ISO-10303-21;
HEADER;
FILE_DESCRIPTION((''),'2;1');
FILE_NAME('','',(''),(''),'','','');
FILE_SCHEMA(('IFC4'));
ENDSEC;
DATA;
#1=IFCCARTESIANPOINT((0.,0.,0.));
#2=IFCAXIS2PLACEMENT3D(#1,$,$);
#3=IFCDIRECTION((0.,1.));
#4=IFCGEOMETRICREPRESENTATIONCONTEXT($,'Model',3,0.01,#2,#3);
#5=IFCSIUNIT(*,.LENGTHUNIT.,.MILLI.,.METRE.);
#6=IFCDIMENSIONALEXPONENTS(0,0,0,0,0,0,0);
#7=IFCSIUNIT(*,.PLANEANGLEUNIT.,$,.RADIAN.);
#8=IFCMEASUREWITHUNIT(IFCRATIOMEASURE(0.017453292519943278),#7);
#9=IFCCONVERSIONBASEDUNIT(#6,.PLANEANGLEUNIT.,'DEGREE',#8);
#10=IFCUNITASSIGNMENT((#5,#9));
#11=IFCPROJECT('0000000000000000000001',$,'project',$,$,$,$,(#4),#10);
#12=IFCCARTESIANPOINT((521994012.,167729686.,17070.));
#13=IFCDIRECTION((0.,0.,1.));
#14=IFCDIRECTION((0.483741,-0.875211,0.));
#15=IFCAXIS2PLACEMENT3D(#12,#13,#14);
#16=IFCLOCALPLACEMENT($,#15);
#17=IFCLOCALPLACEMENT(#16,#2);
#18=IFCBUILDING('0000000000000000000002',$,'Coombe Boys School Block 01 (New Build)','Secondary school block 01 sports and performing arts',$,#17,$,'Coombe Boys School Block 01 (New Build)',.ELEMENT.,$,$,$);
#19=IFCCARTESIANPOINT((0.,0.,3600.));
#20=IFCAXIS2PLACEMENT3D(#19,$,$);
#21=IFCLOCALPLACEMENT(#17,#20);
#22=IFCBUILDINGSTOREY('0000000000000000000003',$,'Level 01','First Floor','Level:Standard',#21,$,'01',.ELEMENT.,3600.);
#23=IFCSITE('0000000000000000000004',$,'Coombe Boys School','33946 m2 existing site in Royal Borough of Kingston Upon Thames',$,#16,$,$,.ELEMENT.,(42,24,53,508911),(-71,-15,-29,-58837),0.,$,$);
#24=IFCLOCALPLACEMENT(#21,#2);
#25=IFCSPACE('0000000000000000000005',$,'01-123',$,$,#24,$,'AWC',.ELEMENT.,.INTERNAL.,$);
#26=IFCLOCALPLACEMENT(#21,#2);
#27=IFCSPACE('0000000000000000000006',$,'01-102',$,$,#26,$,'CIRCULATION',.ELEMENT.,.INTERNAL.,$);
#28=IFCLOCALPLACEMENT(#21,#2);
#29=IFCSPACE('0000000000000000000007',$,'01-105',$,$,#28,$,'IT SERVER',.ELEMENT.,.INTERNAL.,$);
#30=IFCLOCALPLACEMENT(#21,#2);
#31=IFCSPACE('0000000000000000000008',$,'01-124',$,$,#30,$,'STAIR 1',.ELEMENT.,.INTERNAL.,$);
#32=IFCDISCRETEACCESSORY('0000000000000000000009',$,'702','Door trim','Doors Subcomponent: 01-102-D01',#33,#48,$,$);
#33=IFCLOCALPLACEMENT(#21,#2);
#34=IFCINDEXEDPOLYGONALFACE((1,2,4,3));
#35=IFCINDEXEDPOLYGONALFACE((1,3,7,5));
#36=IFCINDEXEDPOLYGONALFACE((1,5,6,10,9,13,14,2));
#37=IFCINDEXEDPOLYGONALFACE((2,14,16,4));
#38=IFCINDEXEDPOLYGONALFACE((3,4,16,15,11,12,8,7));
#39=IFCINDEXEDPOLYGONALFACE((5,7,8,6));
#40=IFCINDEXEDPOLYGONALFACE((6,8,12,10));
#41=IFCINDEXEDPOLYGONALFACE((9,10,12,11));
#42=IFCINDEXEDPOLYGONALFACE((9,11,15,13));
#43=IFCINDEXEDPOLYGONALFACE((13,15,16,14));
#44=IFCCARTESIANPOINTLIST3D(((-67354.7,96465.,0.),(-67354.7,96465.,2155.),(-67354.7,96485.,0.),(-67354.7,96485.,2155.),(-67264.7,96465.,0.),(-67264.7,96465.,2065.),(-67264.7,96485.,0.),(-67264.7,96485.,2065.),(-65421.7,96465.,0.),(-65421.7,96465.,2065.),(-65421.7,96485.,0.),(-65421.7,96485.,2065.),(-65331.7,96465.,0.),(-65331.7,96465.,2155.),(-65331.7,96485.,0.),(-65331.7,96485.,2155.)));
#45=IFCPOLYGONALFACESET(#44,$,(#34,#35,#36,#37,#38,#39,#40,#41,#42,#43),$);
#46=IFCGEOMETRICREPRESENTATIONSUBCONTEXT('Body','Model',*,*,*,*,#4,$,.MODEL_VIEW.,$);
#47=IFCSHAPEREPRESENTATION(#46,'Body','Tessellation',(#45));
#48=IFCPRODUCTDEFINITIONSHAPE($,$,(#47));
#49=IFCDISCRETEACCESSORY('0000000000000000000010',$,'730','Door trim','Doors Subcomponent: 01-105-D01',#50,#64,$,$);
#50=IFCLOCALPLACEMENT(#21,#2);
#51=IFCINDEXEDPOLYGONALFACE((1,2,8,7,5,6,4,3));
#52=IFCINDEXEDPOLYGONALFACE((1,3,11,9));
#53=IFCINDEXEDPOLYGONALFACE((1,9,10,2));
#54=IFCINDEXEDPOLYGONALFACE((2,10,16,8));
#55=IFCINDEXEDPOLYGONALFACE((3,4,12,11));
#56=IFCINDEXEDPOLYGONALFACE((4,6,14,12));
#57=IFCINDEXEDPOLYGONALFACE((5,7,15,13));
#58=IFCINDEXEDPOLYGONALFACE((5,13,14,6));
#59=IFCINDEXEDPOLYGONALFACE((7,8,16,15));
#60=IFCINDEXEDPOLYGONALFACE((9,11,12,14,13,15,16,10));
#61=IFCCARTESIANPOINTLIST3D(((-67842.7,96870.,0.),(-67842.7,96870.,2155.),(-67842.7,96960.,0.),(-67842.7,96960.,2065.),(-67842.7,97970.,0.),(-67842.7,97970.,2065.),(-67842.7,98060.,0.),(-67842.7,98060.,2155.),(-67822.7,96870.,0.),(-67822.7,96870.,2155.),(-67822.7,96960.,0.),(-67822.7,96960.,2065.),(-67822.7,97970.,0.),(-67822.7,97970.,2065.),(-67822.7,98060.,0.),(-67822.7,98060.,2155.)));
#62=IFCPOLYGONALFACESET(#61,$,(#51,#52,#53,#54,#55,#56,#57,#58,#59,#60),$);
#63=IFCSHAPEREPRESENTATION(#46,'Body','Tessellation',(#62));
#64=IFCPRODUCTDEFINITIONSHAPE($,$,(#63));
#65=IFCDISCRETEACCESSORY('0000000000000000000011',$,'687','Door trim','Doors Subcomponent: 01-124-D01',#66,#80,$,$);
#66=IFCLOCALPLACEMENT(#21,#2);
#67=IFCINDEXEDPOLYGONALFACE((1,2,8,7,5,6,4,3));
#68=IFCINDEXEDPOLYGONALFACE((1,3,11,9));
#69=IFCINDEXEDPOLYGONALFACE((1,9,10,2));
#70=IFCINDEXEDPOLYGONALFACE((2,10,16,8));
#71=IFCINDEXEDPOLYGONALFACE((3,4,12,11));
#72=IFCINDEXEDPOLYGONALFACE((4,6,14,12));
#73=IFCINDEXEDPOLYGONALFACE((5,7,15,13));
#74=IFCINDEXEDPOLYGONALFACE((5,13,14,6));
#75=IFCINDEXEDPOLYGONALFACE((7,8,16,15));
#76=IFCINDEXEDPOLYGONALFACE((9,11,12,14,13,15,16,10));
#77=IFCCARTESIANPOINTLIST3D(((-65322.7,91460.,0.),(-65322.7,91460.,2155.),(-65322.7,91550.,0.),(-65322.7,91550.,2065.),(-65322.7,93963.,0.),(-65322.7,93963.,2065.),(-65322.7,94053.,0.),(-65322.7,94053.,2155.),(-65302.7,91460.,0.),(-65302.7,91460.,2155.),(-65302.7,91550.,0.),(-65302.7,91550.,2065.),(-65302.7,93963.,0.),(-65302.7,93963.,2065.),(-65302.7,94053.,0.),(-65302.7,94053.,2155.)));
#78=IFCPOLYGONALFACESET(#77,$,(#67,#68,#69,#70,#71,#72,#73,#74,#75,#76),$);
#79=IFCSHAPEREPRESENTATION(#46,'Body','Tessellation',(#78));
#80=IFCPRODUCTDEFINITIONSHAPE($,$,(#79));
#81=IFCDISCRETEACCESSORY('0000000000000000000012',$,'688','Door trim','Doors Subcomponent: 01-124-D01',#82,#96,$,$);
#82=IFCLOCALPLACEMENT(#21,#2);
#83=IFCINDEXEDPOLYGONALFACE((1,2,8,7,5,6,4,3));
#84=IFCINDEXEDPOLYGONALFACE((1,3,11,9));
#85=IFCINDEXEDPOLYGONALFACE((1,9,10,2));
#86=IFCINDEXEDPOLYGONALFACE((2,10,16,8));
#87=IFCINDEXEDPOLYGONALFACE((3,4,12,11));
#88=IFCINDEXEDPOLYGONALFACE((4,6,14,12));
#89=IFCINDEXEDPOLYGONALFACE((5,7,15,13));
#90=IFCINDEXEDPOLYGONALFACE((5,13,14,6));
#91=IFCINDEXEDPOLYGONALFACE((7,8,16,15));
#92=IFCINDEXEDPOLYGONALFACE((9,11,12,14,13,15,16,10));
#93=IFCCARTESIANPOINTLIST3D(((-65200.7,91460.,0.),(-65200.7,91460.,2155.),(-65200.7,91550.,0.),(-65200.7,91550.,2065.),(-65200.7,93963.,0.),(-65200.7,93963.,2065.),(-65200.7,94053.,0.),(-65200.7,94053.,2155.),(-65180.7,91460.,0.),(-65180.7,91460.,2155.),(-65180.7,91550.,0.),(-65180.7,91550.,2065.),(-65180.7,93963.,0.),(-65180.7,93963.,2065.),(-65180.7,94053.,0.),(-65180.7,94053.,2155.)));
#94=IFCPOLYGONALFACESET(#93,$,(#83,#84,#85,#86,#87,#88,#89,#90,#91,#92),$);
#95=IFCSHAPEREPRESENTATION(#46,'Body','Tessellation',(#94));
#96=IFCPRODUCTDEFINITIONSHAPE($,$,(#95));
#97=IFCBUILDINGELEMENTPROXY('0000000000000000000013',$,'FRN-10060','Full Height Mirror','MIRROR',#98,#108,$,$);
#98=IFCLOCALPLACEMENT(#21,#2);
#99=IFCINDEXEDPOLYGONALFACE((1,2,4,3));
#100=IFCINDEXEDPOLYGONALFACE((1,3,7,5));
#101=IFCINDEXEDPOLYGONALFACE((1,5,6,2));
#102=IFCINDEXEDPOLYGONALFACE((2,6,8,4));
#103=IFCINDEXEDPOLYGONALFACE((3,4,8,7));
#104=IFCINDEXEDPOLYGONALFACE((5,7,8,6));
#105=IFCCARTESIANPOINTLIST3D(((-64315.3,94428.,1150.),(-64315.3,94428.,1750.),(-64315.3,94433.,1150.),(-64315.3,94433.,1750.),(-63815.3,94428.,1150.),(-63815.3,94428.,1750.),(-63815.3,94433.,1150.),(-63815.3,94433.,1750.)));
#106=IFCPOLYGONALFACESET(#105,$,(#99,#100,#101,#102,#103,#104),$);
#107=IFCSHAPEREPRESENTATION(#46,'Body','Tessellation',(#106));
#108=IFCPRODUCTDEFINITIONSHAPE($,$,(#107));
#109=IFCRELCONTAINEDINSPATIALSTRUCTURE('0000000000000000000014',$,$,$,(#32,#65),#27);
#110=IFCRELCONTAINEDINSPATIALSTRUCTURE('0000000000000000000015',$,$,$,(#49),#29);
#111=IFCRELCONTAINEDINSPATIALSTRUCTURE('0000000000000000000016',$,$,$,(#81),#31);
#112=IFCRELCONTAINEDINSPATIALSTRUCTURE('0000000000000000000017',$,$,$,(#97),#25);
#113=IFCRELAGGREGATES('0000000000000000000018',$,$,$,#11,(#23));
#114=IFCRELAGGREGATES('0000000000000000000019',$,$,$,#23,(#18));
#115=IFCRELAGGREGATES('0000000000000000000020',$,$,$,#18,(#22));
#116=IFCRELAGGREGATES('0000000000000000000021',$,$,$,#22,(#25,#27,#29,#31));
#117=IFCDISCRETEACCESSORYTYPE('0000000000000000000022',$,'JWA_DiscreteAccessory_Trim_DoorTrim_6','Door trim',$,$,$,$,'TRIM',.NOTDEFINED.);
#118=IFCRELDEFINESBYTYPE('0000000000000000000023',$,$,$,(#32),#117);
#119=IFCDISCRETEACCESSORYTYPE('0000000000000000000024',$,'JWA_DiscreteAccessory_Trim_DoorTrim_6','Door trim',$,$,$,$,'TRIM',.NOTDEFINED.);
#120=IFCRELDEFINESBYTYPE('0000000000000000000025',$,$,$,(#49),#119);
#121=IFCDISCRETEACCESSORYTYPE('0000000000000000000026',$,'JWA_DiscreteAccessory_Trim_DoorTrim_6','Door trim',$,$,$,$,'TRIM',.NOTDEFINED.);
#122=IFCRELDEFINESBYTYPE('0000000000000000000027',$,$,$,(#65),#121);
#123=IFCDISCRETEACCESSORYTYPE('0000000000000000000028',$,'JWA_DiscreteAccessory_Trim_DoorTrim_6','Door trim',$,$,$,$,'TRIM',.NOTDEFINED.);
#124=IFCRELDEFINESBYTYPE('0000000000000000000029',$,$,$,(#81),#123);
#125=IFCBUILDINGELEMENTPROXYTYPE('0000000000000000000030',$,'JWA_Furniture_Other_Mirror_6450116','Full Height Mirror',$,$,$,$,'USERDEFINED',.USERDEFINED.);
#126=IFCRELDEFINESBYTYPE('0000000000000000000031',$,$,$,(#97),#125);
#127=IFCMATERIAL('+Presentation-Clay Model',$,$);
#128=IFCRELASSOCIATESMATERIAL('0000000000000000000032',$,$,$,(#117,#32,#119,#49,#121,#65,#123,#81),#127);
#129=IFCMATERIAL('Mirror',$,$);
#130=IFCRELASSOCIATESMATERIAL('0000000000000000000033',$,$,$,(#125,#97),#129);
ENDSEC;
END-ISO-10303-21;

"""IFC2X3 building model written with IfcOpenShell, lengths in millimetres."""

from ifc_helpers import new_model, entity, si_unit, converted_unit, direction, frame, origin, origin_2d_with_axis, place, context, subcontext, project, spatial, polyline, rectangle, outline, extrude, source, transform, mapped, material, type_object, type_shapes, element, save


model = new_model("IFC2X3")

# Units and contexts
model_context = context("Model", 3, precision=0.01, world=origin(), true_north=direction((0.0, 1.0)))
body_context = subcontext(model_context, "Body", "Model", "MODEL_VIEW")
ifc_project = project(units=[si_unit("LENGTHUNIT", "METRE", prefix="MILLI"), converted_unit("PLANEANGLEUNIT", "DEGREE", entity("IfcRatioMeasure", 0.017453292519943278), si_unit("PLANEANGLEUNIT", "RADIAN"), dimensions=[0, 0, 0, 0, 0, 0, 0])], contexts=[model_context])

# Site, building, storey
site_placement = place(None, frame((521994012.0, 167729686.0, 17070.0), z_axis=(0.0, 0.0, 1.0), x_axis=(0.483741, -0.875211, 0.0)))
site = spatial("IfcSite", under=ifc_project, at=site_placement, Name="Coombe Boys School", Description="33946 m2 existing site in Royal Borough of Kingston Upon Thames", CompositionType="ELEMENT", RefLatitude=(42, 24, 53, 508911), RefLongitude=(-71, -15, -29, -58837), RefElevation=0.0)
building_placement = place(site_placement, origin())
building = spatial("IfcBuilding", under=site, at=building_placement, Name="Coombe Boys School Block 01 (New Build)", Description="Secondary school block 01 sports and performing arts", LongName="Coombe Boys School Block 01 (New Build)", CompositionType="ELEMENT")
storey_placement = place(building_placement, frame((0.0, 0.0, 3600.0)))
storey = spatial("IfcBuildingStorey", under=building, at=storey_placement, Name="Level 01", Description="First Floor", ObjectType="Level:Standard", LongName="01", CompositionType="ELEMENT", Elevation=3600.0)

# Shared definitions
space_1_placement = place(storey_placement, origin())
space_1 = spatial("IfcSpace", under=storey, at=space_1_placement, Name="01-123", LongName="AWC", CompositionType="ELEMENT", InteriorOrExteriorSpace="INTERNAL")

# Shared definitions
ifc_material_1 = material(Name="+Presentation-Clay Model")

# Shared definitions
space_2_placement = place(storey_placement, origin())
space_2 = spatial("IfcSpace", under=storey, at=space_2_placement, Name="01-102", LongName="CIRCULATION", CompositionType="ELEMENT", InteriorOrExteriorSpace="INTERNAL")

# Discrete accessory
discrete_accessory_type_1 = type_object("IfcDiscreteAccessoryType", Name="JWA_DiscreteAccessory_Trim_DoorTrim_6", Description="Door trim", ElementType="TRIM", material=ifc_material_1)
shared_shape_1 = source(origin(), body_context, "Body", "SweptSolid", [
    extrude(outline(polyline([(921.5, -1055.0), (1011.5, -1055.0), (1011.5, 1100.0), (-1011.5, 1100.0), (-1011.5, -1055.0), (-921.5, -1055.0), (-921.5, 1010.0), (921.5, 1010.0), (921.5, -1055.0)])), frame((0.0, 0.0, 1055.0), z_axis=(0.0, 1.0, 0.0), x_axis=(-1.0, 0.0, 0.0)), (0.0, 0.0, 1.0), 20.0),
])
type_shapes(discrete_accessory_type_1, [shared_shape_1])
discrete_accessory_1_placement = place(space_2_placement, frame((-66343.2, 96485.0, 0.0), z_axis=(0.0, 0.0, 1.0), x_axis=(-1.0, 0.0, 0.0)))
element("IfcDiscreteAccessory", 1, at=discrete_accessory_1_placement, inside=space_2, type_object=discrete_accessory_type_1, material=ifc_material_1, Name="702", Description="Door trim", ObjectType="Doors Subcomponent: 01-102-D01", context=body_context, shape_type="MappedRepresentation", body=[
    mapped(shared_shape_1, transform((0.0, 0.0, 0.0), scale=1.0)),
])

# Shared definitions
space_3_placement = place(storey_placement, origin())
space_3 = spatial("IfcSpace", under=storey, at=space_3_placement, Name="01-105", LongName="IT SERVER", CompositionType="ELEMENT", InteriorOrExteriorSpace="INTERNAL")

# Discrete accessories
discrete_accessory_type_2 = type_object("IfcDiscreteAccessoryType", Name="JWA_DiscreteAccessory_Trim_DoorTrim_6", Description="Door trim", ElementType="TRIM", material=ifc_material_1)
shared_shape_2 = source(origin(), body_context, "Body", "SweptSolid", [
    extrude(outline(polyline([(505.0, -1055.0), (595.0, -1055.0), (595.0, 1100.0), (-595.0, 1100.0), (-595.0, -1055.0), (-505.0, -1055.0), (-505.0, 1010.0), (505.0, 1010.0), (505.0, -1055.0)])), frame((0.0, 0.0, 1055.0), z_axis=(0.0, 1.0, 0.0), x_axis=(-1.0, 0.0, 0.0)), (0.0, 0.0, 1.0), 20.0),
])
type_shapes(discrete_accessory_type_2, [shared_shape_2])
discrete_accessory_2_placement = place(space_3_placement, frame((-67822.7, 97465.0, 0.0), z_axis=(0.0, 0.0, 1.0), x_axis=(0.0, 1.0, 0.0)))
element("IfcDiscreteAccessory", 2, at=discrete_accessory_2_placement, inside=space_3, type_object=discrete_accessory_type_2, material=ifc_material_1, Name="730", Description="Door trim", ObjectType="Doors Subcomponent: 01-105-D01", context=body_context, shape_type="MappedRepresentation", body=[
    mapped(shared_shape_2, transform((0.0, 0.0, 0.0), scale=1.0)),
])
discrete_accessory_type_3 = type_object("IfcDiscreteAccessoryType", Name="JWA_DiscreteAccessory_Trim_DoorTrim_6", Description="Door trim", ElementType="TRIM", material=ifc_material_1)
shared_shape_3 = source(origin(), body_context, "Body", "SweptSolid", [
    extrude(outline(polyline([(1206.5, -1055.0), (1296.5, -1055.0), (1296.5, 1100.0), (-1296.5, 1100.0), (-1296.5, -1055.0), (-1206.5, -1055.0), (-1206.5, 1010.0), (1206.5, 1010.0), (1206.5, -1055.0)])), frame((0.0, 0.0, 1055.0), z_axis=(0.0, 1.0, 0.0), x_axis=(-1.0, 0.0, 0.0)), (0.0, 0.0, 1.0), 20.0),
])
type_shapes(discrete_accessory_type_3, [shared_shape_3])
discrete_accessory_3_placement = place(space_2_placement, frame((-65302.7, 92756.5, 0.0), z_axis=(0.0, 0.0, 1.0), x_axis=(0.0, 1.0, 0.0)))
element("IfcDiscreteAccessory", 3, at=discrete_accessory_3_placement, inside=space_2, type_object=discrete_accessory_type_3, material=ifc_material_1, Name="687", Description="Door trim", ObjectType="Doors Subcomponent: 01-124-D01", context=body_context, shape_type="MappedRepresentation", body=[
    mapped(shared_shape_3, transform((0.0, 0.0, 0.0), scale=1.0)),
])

# Shared definitions
space_4_placement = place(storey_placement, origin())
space_4 = spatial("IfcSpace", under=storey, at=space_4_placement, Name="01-124", LongName="STAIR 1", CompositionType="ELEMENT", InteriorOrExteriorSpace="INTERNAL")

# Discrete accessory
discrete_accessory_type_4 = type_object("IfcDiscreteAccessoryType", Name="JWA_DiscreteAccessory_Trim_DoorTrim_6", Description="Door trim", ElementType="TRIM", material=ifc_material_1)
shared_shape_4 = source(origin(), body_context, "Body", "SweptSolid", [
    extrude(outline(polyline([(-1055.0, -1296.5), (1100.0, -1296.5), (1100.0, 1296.5), (-1055.0, 1296.5), (-1055.0, 1206.5), (1010.0, 1206.5), (1010.0, -1206.5), (-1055.0, -1206.5), (-1055.0, -1296.5)])), frame((0.0, -20.0, 1055.0), z_axis=(0.0, 1.0, 0.0), x_axis=(0.0, 0.0, 1.0)), (0.0, 0.0, 1.0), 20.0),
])
type_shapes(discrete_accessory_type_4, [shared_shape_4])
discrete_accessory_4_placement = place(space_4_placement, frame((-65200.7, 92756.5, 0.0), z_axis=(0.0, 0.0, 1.0), x_axis=(0.0, 1.0, 0.0)))
element("IfcDiscreteAccessory", 4, at=discrete_accessory_4_placement, inside=space_4, type_object=discrete_accessory_type_4, material=ifc_material_1, Name="688", Description="Door trim", ObjectType="Doors Subcomponent: 01-124-D01", context=body_context, shape_type="MappedRepresentation", body=[
    mapped(shared_shape_4, transform((0.0, 0.0, 0.0), scale=1.0)),
])

# Building element proxy
ifc_material_2 = material(Name="Mirror")
building_element_proxy_type = type_object("IfcBuildingElementProxyType", Name="JWA_Furniture_Other_Mirror_6450116", Description="Full Height Mirror", ElementType="USERDEFINED", PredefinedType="USERDEFINED", material=ifc_material_2)
shared_shape_5 = source(origin(), body_context, "Body", "SweptSolid", [
    extrude(rectangle(XDim=5.0, YDim=500.0, at=origin_2d_with_axis()), frame((0.0, -2.5, 0.0), z_axis=(0.0, 0.0, 1.0), x_axis=(0.0, 1.0, 0.0)), (0.0, 0.0, 1.0), 600.0),
])
type_shapes(building_element_proxy_type, [shared_shape_5])
proxy_placement = place(space_1_placement, frame((-64065.3, 94428.0, 1150.0), z_axis=(0.0, 0.0, 1.0), x_axis=(-1.0, 0.0, 0.0)))
element("IfcBuildingElementProxy", 5, at=proxy_placement, inside=space_1, type_object=building_element_proxy_type, material=ifc_material_2, Name="FRN-10060", Description="Full Height Mirror", ObjectType="MIRROR", context=body_context, shape_type="MappedRepresentation", body=[
    mapped(shared_shape_5, transform((0.0, 0.0, 0.0), scale=1.0)),
])

save(model, "model.ifc")
